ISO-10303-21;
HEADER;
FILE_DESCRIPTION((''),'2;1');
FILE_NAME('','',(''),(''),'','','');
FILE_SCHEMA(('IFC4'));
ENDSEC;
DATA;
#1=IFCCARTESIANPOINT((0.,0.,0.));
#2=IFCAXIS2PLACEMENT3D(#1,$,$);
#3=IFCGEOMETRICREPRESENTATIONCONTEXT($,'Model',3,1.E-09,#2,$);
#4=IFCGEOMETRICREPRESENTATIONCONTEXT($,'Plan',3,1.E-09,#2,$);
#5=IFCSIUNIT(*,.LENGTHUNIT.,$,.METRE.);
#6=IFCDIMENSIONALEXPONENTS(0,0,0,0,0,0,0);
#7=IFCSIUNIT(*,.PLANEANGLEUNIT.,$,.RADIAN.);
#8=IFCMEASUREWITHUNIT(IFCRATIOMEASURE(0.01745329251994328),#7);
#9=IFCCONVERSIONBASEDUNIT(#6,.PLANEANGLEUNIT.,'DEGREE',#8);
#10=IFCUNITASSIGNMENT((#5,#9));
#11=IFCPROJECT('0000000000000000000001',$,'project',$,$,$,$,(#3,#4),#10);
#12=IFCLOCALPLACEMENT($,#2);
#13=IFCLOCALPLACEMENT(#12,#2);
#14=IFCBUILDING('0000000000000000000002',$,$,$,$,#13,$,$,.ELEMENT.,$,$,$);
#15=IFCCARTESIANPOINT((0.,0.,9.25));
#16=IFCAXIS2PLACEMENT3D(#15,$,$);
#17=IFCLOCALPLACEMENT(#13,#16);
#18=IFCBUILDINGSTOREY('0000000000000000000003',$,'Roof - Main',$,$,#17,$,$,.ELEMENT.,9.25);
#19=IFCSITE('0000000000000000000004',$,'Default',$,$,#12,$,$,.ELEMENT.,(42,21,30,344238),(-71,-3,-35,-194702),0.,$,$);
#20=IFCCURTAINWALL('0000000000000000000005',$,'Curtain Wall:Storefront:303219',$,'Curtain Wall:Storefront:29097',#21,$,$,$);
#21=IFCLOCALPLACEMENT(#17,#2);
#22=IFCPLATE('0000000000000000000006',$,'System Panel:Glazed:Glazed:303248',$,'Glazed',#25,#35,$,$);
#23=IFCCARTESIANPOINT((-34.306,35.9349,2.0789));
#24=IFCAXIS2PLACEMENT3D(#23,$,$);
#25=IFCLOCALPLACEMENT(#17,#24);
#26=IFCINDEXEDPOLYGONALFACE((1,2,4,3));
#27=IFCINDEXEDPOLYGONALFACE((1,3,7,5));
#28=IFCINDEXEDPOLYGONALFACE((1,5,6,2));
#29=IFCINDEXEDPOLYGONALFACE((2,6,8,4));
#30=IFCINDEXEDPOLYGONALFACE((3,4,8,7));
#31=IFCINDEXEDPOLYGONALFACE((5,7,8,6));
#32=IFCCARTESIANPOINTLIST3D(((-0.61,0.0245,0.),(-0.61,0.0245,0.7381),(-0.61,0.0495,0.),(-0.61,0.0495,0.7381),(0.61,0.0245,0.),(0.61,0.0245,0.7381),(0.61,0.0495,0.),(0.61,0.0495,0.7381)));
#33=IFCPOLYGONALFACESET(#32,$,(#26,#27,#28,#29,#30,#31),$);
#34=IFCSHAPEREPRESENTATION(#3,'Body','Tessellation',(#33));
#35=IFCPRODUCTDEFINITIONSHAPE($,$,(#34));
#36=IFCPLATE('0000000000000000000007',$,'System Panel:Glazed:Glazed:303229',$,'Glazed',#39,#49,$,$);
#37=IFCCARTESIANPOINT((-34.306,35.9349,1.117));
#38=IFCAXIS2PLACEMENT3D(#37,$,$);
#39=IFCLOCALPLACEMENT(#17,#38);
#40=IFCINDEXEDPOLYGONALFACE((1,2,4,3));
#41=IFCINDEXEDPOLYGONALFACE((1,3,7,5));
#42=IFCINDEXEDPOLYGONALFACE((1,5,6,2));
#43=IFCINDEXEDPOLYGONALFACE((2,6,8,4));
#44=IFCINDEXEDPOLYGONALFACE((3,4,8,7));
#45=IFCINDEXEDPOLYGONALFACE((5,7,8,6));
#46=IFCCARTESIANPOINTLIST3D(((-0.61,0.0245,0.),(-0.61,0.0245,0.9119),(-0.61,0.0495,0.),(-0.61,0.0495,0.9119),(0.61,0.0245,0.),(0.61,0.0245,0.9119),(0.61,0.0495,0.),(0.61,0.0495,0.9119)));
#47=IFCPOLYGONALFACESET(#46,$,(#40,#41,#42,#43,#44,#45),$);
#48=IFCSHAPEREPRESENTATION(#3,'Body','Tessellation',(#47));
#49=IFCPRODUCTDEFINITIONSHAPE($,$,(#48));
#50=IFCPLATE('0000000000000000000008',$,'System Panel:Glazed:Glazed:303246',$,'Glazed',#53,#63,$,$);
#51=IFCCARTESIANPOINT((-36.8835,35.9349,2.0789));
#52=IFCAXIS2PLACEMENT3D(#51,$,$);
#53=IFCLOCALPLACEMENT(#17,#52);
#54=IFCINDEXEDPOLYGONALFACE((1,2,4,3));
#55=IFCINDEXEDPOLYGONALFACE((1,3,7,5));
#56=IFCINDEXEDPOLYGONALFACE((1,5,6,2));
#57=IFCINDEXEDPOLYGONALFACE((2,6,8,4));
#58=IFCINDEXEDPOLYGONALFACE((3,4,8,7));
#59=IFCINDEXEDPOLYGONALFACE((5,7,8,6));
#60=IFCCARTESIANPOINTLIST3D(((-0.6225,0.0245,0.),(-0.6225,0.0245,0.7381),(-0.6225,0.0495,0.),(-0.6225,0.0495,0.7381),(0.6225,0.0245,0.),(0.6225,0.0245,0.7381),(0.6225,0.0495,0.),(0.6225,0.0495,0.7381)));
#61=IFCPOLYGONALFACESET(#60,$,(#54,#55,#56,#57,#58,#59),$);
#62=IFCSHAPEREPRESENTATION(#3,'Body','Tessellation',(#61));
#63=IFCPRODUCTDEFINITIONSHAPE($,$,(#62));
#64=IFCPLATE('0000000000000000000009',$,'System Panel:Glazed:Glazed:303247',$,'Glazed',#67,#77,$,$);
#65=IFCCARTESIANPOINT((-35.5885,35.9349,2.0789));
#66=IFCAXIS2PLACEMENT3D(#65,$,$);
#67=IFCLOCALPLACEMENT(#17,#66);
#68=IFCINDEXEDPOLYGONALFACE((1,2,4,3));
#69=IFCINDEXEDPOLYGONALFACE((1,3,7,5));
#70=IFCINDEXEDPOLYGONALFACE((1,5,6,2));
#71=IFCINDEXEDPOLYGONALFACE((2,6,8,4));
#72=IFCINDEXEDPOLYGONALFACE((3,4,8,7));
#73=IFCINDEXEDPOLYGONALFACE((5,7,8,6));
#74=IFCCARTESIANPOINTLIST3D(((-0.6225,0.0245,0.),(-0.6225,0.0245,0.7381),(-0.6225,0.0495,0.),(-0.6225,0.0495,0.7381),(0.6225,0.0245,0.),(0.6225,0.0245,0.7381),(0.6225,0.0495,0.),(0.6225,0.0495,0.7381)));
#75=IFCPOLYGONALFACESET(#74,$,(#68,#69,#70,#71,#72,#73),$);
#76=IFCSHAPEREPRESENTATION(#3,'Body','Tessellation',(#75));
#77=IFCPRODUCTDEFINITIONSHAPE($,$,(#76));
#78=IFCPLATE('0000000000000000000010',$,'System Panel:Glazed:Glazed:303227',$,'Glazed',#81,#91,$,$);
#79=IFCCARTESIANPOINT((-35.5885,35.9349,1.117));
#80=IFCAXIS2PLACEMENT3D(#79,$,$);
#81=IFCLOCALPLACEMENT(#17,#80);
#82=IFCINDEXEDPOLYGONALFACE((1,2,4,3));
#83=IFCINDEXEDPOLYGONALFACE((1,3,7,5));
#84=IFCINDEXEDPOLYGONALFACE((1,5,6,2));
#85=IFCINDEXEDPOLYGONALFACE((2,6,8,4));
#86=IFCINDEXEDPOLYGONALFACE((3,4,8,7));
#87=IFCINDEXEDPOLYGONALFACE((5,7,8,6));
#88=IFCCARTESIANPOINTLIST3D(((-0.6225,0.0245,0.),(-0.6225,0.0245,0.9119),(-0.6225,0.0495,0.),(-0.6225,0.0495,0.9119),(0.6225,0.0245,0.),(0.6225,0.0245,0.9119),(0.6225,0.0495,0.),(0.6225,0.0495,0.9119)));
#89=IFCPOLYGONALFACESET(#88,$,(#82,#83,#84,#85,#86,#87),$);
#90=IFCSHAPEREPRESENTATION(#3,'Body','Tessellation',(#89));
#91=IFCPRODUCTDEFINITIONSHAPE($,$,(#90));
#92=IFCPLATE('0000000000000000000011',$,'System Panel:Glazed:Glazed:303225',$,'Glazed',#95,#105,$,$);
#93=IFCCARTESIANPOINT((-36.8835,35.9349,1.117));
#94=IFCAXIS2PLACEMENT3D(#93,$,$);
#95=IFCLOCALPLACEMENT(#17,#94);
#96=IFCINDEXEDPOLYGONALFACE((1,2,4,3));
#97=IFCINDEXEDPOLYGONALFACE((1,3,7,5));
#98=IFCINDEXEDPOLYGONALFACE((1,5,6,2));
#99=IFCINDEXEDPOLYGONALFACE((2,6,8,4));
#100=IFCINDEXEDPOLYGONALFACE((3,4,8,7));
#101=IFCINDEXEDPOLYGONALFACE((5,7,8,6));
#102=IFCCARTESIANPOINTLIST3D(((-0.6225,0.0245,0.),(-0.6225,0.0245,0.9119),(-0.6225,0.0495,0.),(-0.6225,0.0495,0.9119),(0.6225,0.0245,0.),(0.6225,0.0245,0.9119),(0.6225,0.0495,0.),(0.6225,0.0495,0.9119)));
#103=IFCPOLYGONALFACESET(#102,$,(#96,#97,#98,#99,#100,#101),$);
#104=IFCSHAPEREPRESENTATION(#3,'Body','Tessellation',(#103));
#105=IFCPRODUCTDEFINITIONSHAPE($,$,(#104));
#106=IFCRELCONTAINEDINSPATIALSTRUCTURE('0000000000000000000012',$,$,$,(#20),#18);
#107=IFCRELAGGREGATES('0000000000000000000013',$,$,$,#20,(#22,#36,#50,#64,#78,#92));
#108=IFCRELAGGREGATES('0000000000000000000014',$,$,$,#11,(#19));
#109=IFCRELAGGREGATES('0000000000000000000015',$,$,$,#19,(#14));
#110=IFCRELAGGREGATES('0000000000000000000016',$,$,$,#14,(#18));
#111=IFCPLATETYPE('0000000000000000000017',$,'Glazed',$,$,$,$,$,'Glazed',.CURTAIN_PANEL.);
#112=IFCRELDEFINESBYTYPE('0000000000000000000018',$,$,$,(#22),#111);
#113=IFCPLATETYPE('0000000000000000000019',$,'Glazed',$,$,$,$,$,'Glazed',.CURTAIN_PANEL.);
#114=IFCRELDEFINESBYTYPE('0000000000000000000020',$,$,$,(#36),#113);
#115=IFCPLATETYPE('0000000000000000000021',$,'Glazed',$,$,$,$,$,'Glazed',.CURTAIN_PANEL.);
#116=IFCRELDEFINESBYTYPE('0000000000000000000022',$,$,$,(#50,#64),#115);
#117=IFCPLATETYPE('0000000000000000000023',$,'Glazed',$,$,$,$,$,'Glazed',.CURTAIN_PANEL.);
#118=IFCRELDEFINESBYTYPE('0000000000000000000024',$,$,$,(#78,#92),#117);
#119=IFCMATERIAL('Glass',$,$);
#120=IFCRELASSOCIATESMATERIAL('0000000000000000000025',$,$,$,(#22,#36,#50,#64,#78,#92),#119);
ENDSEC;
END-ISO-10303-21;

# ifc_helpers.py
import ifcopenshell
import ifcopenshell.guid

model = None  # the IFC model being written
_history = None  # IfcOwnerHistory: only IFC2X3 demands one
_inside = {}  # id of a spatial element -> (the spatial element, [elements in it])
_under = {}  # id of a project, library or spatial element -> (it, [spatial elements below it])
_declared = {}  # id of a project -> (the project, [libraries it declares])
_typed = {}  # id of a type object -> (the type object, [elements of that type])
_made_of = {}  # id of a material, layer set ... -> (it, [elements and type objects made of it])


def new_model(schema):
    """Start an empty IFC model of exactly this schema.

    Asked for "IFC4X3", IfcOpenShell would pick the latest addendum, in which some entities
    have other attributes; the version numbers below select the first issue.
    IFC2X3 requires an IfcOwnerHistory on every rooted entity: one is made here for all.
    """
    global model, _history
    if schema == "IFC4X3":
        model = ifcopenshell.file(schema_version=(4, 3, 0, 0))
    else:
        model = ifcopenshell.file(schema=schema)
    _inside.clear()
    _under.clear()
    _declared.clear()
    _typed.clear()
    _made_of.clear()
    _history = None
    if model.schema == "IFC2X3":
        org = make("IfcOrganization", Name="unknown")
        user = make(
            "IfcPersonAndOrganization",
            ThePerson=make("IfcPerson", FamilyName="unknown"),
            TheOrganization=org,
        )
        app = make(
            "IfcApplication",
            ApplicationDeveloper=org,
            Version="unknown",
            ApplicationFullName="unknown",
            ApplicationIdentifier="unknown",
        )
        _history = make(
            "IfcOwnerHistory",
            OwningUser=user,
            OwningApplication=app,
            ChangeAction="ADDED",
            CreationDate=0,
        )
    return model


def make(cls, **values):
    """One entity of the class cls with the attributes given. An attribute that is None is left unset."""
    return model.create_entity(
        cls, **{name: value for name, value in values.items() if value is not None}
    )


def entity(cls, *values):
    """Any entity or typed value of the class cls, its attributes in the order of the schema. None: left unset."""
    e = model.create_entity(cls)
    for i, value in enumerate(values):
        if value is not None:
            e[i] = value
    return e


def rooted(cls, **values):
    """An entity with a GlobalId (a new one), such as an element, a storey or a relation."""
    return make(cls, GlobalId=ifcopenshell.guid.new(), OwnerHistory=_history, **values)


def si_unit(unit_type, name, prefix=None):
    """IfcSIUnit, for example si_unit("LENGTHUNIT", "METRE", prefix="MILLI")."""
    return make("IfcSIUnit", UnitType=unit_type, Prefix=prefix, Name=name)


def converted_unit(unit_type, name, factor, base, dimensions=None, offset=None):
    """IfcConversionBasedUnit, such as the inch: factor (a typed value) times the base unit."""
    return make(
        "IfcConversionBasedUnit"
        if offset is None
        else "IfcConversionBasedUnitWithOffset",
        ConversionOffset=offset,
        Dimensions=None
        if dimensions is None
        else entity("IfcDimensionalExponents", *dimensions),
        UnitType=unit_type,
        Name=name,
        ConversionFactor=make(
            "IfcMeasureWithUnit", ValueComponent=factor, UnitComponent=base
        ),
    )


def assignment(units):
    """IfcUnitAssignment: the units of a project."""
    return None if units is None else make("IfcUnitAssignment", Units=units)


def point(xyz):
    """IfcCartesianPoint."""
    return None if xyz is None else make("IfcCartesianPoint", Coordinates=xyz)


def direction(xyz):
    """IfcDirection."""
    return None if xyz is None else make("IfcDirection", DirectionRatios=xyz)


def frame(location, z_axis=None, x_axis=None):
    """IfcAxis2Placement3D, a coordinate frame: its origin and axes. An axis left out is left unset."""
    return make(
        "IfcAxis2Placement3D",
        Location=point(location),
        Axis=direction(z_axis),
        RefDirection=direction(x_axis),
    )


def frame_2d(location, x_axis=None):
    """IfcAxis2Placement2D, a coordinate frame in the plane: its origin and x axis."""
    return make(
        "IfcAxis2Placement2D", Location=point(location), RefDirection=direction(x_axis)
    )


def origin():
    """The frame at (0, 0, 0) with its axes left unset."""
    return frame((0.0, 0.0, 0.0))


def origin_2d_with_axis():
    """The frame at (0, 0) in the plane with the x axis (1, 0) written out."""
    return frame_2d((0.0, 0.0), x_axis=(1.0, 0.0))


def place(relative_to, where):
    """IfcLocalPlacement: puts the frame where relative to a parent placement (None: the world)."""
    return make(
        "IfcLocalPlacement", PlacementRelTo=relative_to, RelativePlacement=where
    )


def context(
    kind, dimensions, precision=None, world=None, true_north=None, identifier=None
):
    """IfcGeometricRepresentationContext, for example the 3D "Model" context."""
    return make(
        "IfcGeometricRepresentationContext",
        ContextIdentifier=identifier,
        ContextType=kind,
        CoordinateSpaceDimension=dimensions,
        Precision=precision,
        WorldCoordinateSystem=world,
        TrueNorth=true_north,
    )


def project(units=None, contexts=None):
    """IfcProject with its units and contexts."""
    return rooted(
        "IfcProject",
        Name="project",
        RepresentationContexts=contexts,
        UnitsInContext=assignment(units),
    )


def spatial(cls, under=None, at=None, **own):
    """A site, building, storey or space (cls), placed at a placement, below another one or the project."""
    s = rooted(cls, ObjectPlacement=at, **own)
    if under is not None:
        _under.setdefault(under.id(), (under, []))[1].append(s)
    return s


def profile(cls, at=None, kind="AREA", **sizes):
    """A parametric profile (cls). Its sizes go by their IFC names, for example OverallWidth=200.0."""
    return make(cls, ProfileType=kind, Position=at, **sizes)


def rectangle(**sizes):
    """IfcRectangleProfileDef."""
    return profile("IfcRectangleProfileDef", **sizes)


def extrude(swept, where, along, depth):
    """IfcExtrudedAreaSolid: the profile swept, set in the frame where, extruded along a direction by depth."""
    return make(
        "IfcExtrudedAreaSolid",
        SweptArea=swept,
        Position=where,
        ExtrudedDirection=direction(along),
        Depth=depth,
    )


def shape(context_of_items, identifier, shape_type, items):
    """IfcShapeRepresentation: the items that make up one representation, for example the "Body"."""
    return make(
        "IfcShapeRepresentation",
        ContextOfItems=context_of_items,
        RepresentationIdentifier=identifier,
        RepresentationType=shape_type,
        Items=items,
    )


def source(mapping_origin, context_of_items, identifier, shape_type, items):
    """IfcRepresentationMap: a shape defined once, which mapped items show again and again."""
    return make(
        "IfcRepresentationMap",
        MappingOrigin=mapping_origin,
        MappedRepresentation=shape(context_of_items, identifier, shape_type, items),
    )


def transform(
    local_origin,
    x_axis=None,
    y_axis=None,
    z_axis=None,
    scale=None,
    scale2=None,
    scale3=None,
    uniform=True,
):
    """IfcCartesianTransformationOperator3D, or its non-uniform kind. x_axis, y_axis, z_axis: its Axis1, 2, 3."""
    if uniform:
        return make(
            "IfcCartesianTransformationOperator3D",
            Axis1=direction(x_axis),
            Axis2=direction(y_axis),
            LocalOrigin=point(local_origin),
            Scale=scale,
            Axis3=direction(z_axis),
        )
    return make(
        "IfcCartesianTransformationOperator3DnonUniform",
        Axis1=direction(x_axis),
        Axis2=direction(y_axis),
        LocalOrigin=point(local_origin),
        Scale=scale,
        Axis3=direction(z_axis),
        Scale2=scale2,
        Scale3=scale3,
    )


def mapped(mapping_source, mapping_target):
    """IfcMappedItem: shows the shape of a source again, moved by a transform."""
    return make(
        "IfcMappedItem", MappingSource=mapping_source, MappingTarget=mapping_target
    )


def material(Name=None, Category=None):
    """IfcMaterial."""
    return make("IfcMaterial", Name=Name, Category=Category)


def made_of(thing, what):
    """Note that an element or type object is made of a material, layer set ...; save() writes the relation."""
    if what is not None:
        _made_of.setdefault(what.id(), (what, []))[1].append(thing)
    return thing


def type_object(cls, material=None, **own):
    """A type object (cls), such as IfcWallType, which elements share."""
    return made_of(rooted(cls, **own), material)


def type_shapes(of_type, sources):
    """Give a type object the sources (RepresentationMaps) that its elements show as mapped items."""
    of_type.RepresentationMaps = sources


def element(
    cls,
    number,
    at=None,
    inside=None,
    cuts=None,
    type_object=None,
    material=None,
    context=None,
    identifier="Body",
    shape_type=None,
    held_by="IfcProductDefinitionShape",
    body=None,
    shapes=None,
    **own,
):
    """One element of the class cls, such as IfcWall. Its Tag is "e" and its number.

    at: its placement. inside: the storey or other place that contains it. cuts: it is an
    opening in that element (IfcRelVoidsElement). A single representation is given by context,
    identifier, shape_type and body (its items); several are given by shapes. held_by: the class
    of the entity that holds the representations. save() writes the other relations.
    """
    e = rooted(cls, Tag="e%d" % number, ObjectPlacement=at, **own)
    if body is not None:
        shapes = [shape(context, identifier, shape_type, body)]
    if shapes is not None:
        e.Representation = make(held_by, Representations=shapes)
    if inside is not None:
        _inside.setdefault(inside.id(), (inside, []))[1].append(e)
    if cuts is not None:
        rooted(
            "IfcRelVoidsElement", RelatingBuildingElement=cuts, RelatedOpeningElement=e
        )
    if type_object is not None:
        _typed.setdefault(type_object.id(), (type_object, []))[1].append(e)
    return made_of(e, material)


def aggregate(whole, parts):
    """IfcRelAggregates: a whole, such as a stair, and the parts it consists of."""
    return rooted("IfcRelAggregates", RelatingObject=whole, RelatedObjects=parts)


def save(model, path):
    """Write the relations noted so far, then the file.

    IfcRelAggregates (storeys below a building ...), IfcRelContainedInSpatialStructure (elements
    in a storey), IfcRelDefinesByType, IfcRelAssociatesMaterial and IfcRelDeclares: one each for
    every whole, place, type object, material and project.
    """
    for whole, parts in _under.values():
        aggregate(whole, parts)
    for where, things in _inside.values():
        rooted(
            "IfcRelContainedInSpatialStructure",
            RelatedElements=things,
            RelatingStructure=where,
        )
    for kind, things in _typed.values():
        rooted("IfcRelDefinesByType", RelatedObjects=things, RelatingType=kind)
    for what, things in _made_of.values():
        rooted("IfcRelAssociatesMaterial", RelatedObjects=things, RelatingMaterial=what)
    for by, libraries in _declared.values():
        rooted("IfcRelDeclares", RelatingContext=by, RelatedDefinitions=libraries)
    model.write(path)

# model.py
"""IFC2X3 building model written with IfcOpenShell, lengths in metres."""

from ifc_helpers import new_model, entity, si_unit, converted_unit, frame, origin, origin_2d_with_axis, place, context, project, spatial, rectangle, extrude, source, transform, mapped, material, type_object, type_shapes, element, aggregate, save


model = new_model("IFC2X3")

# Units and contexts
model_context = context("Model", 3, precision=1e-09, world=origin())
plan_context = context("Plan", 3, precision=1e-09, world=origin())
ifc_project = project(units=[si_unit("LENGTHUNIT", "METRE"), converted_unit("PLANEANGLEUNIT", "DEGREE", entity("IfcRatioMeasure", 0.01745329251994328), si_unit("PLANEANGLEUNIT", "RADIAN"), dimensions=[0, 0, 0, 0, 0, 0, 0])], contexts=[model_context, plan_context])

# Site, building, storey
site_placement = place(None, origin())
site = spatial("IfcSite", under=ifc_project, at=site_placement, Name="Default", CompositionType="ELEMENT", RefLatitude=(42, 21, 30, 344238), RefLongitude=(-71, -3, -35, -194702), RefElevation=0.0)
building_placement = place(site_placement, origin())
building = spatial("IfcBuilding", under=site, at=building_placement, CompositionType="ELEMENT")
storey_placement = place(building_placement, frame((0.0, 0.0, 9.25)))
storey = spatial("IfcBuildingStorey", under=building, at=storey_placement, Name="Roof - Main", CompositionType="ELEMENT", Elevation=9.25)

# Curtain wall, plates
curtain_wall_placement = place(storey_placement, origin())
curtain_wall = element("IfcCurtainWall", 1, at=curtain_wall_placement, inside=storey, Name="Curtain Wall:Storefront:303219", ObjectType="Curtain Wall:Storefront:29097")
ifc_material_1 = material(Name="Glass")
plate_type_1 = type_object("IfcPlateType", Name="Glazed", ElementType="Glazed", PredefinedType="CURTAIN_PANEL")
shared_shape_1 = source(origin(), model_context, "Body", "SweptSolid", [
    extrude(rectangle(XDim=0.025, YDim=1.22, at=origin_2d_with_axis()), frame((0.0, 0.037, 0.0), z_axis=(0.0, 0.0, 1.0), x_axis=(0.0, 1.0, 0.0)), (0.0, 0.0, 1.0), 0.7381),
])
type_shapes(plate_type_1, [shared_shape_1])
plate_1_placement = place(storey_placement, frame((-34.306, 35.9349, 2.0789)))
plate_1 = element("IfcPlate", 2, at=plate_1_placement, type_object=plate_type_1, material=ifc_material_1, Name="System Panel:Glazed:Glazed:303248", ObjectType="Glazed", context=model_context, shape_type="MappedRepresentation", body=[
    mapped(shared_shape_1, transform((0.0, 0.0, 0.0), scale=1.0)),
])
plate_type_2 = type_object("IfcPlateType", Name="Glazed", ElementType="Glazed", PredefinedType="CURTAIN_PANEL")
shared_shape_2 = source(origin(), model_context, "Body", "SweptSolid", [
    extrude(rectangle(XDim=0.025, YDim=1.22, at=origin_2d_with_axis()), frame((0.0, 0.037, 0.0), z_axis=(0.0, 0.0, 1.0), x_axis=(0.0, 1.0, 0.0)), (0.0, 0.0, 1.0), 0.9119),
])
type_shapes(plate_type_2, [shared_shape_2])
plate_2_placement = place(storey_placement, frame((-34.306, 35.9349, 1.117)))
plate_2 = element("IfcPlate", 3, at=plate_2_placement, type_object=plate_type_2, material=ifc_material_1, Name="System Panel:Glazed:Glazed:303229", ObjectType="Glazed", context=model_context, shape_type="MappedRepresentation", body=[
    mapped(shared_shape_2, transform((0.0, 0.0, 0.0), scale=1.0)),
])
plate_type_3 = type_object("IfcPlateType", Name="Glazed", ElementType="Glazed", PredefinedType="CURTAIN_PANEL")
shared_shape_3 = source(origin(), model_context, "Body", "SweptSolid", [
    extrude(rectangle(XDim=0.025, YDim=1.245, at=origin_2d_with_axis()), frame((0.0, 0.037, 0.0), z_axis=(0.0, 0.0, 1.0), x_axis=(0.0, 1.0, 0.0)), (0.0, 0.0, 1.0), 0.7381),
])
type_shapes(plate_type_3, [shared_shape_3])
plate_3_placement = place(storey_placement, frame((-36.8835, 35.9349, 2.0789)))
plate_3 = element("IfcPlate", 4, at=plate_3_placement, type_object=plate_type_3, material=ifc_material_1, Name="System Panel:Glazed:Glazed:303246", ObjectType="Glazed", context=model_context, shape_type="MappedRepresentation", body=[
    mapped(shared_shape_3, transform((0.0, 0.0, 0.0), scale=1.0)),
])
plate_4_placement = place(storey_placement, frame((-35.5885, 35.9349, 2.0789)))
plate_4 = element("IfcPlate", 5, at=plate_4_placement, type_object=plate_type_3, material=ifc_material_1, Name="System Panel:Glazed:Glazed:303247", ObjectType="Glazed", context=model_context, shape_type="MappedRepresentation", body=[
    mapped(shared_shape_3, transform((0.0, 0.0, 0.0), scale=1.0)),
])
plate_type_4 = type_object("IfcPlateType", Name="Glazed", ElementType="Glazed", PredefinedType="CURTAIN_PANEL")
shared_shape_4 = source(origin(), model_context, "Body", "SweptSolid", [
    extrude(rectangle(XDim=0.025, YDim=1.245, at=origin_2d_with_axis()), frame((0.0, 0.037, 0.0), z_axis=(0.0, 0.0, 1.0), x_axis=(0.0, 1.0, 0.0)), (0.0, 0.0, 1.0), 0.9119),
])
type_shapes(plate_type_4, [shared_shape_4])
plate_5_placement = place(storey_placement, frame((-35.5885, 35.9349, 1.117)))
plate_5 = element("IfcPlate", 6, at=plate_5_placement, type_object=plate_type_4, material=ifc_material_1, Name="System Panel:Glazed:Glazed:303227", ObjectType="Glazed", context=model_context, shape_type="MappedRepresentation", body=[
    mapped(shared_shape_4, transform((0.0, 0.0, 0.0), scale=1.0)),
])
plate_6_placement = place(storey_placement, frame((-36.8835, 35.9349, 1.117)))
plate_6 = element("IfcPlate", 7, at=plate_6_placement, type_object=plate_type_4, material=ifc_material_1, Name="System Panel:Glazed:Glazed:303225", ObjectType="Glazed", context=model_context, shape_type="MappedRepresentation", body=[
    mapped(shared_shape_4, transform((0.0, 0.0, 0.0), scale=1.0)),
])
aggregate(curtain_wall, [plate_1, plate_2, plate_3, plate_4, plate_5, plate_6])

save(model, "model.ifc")
